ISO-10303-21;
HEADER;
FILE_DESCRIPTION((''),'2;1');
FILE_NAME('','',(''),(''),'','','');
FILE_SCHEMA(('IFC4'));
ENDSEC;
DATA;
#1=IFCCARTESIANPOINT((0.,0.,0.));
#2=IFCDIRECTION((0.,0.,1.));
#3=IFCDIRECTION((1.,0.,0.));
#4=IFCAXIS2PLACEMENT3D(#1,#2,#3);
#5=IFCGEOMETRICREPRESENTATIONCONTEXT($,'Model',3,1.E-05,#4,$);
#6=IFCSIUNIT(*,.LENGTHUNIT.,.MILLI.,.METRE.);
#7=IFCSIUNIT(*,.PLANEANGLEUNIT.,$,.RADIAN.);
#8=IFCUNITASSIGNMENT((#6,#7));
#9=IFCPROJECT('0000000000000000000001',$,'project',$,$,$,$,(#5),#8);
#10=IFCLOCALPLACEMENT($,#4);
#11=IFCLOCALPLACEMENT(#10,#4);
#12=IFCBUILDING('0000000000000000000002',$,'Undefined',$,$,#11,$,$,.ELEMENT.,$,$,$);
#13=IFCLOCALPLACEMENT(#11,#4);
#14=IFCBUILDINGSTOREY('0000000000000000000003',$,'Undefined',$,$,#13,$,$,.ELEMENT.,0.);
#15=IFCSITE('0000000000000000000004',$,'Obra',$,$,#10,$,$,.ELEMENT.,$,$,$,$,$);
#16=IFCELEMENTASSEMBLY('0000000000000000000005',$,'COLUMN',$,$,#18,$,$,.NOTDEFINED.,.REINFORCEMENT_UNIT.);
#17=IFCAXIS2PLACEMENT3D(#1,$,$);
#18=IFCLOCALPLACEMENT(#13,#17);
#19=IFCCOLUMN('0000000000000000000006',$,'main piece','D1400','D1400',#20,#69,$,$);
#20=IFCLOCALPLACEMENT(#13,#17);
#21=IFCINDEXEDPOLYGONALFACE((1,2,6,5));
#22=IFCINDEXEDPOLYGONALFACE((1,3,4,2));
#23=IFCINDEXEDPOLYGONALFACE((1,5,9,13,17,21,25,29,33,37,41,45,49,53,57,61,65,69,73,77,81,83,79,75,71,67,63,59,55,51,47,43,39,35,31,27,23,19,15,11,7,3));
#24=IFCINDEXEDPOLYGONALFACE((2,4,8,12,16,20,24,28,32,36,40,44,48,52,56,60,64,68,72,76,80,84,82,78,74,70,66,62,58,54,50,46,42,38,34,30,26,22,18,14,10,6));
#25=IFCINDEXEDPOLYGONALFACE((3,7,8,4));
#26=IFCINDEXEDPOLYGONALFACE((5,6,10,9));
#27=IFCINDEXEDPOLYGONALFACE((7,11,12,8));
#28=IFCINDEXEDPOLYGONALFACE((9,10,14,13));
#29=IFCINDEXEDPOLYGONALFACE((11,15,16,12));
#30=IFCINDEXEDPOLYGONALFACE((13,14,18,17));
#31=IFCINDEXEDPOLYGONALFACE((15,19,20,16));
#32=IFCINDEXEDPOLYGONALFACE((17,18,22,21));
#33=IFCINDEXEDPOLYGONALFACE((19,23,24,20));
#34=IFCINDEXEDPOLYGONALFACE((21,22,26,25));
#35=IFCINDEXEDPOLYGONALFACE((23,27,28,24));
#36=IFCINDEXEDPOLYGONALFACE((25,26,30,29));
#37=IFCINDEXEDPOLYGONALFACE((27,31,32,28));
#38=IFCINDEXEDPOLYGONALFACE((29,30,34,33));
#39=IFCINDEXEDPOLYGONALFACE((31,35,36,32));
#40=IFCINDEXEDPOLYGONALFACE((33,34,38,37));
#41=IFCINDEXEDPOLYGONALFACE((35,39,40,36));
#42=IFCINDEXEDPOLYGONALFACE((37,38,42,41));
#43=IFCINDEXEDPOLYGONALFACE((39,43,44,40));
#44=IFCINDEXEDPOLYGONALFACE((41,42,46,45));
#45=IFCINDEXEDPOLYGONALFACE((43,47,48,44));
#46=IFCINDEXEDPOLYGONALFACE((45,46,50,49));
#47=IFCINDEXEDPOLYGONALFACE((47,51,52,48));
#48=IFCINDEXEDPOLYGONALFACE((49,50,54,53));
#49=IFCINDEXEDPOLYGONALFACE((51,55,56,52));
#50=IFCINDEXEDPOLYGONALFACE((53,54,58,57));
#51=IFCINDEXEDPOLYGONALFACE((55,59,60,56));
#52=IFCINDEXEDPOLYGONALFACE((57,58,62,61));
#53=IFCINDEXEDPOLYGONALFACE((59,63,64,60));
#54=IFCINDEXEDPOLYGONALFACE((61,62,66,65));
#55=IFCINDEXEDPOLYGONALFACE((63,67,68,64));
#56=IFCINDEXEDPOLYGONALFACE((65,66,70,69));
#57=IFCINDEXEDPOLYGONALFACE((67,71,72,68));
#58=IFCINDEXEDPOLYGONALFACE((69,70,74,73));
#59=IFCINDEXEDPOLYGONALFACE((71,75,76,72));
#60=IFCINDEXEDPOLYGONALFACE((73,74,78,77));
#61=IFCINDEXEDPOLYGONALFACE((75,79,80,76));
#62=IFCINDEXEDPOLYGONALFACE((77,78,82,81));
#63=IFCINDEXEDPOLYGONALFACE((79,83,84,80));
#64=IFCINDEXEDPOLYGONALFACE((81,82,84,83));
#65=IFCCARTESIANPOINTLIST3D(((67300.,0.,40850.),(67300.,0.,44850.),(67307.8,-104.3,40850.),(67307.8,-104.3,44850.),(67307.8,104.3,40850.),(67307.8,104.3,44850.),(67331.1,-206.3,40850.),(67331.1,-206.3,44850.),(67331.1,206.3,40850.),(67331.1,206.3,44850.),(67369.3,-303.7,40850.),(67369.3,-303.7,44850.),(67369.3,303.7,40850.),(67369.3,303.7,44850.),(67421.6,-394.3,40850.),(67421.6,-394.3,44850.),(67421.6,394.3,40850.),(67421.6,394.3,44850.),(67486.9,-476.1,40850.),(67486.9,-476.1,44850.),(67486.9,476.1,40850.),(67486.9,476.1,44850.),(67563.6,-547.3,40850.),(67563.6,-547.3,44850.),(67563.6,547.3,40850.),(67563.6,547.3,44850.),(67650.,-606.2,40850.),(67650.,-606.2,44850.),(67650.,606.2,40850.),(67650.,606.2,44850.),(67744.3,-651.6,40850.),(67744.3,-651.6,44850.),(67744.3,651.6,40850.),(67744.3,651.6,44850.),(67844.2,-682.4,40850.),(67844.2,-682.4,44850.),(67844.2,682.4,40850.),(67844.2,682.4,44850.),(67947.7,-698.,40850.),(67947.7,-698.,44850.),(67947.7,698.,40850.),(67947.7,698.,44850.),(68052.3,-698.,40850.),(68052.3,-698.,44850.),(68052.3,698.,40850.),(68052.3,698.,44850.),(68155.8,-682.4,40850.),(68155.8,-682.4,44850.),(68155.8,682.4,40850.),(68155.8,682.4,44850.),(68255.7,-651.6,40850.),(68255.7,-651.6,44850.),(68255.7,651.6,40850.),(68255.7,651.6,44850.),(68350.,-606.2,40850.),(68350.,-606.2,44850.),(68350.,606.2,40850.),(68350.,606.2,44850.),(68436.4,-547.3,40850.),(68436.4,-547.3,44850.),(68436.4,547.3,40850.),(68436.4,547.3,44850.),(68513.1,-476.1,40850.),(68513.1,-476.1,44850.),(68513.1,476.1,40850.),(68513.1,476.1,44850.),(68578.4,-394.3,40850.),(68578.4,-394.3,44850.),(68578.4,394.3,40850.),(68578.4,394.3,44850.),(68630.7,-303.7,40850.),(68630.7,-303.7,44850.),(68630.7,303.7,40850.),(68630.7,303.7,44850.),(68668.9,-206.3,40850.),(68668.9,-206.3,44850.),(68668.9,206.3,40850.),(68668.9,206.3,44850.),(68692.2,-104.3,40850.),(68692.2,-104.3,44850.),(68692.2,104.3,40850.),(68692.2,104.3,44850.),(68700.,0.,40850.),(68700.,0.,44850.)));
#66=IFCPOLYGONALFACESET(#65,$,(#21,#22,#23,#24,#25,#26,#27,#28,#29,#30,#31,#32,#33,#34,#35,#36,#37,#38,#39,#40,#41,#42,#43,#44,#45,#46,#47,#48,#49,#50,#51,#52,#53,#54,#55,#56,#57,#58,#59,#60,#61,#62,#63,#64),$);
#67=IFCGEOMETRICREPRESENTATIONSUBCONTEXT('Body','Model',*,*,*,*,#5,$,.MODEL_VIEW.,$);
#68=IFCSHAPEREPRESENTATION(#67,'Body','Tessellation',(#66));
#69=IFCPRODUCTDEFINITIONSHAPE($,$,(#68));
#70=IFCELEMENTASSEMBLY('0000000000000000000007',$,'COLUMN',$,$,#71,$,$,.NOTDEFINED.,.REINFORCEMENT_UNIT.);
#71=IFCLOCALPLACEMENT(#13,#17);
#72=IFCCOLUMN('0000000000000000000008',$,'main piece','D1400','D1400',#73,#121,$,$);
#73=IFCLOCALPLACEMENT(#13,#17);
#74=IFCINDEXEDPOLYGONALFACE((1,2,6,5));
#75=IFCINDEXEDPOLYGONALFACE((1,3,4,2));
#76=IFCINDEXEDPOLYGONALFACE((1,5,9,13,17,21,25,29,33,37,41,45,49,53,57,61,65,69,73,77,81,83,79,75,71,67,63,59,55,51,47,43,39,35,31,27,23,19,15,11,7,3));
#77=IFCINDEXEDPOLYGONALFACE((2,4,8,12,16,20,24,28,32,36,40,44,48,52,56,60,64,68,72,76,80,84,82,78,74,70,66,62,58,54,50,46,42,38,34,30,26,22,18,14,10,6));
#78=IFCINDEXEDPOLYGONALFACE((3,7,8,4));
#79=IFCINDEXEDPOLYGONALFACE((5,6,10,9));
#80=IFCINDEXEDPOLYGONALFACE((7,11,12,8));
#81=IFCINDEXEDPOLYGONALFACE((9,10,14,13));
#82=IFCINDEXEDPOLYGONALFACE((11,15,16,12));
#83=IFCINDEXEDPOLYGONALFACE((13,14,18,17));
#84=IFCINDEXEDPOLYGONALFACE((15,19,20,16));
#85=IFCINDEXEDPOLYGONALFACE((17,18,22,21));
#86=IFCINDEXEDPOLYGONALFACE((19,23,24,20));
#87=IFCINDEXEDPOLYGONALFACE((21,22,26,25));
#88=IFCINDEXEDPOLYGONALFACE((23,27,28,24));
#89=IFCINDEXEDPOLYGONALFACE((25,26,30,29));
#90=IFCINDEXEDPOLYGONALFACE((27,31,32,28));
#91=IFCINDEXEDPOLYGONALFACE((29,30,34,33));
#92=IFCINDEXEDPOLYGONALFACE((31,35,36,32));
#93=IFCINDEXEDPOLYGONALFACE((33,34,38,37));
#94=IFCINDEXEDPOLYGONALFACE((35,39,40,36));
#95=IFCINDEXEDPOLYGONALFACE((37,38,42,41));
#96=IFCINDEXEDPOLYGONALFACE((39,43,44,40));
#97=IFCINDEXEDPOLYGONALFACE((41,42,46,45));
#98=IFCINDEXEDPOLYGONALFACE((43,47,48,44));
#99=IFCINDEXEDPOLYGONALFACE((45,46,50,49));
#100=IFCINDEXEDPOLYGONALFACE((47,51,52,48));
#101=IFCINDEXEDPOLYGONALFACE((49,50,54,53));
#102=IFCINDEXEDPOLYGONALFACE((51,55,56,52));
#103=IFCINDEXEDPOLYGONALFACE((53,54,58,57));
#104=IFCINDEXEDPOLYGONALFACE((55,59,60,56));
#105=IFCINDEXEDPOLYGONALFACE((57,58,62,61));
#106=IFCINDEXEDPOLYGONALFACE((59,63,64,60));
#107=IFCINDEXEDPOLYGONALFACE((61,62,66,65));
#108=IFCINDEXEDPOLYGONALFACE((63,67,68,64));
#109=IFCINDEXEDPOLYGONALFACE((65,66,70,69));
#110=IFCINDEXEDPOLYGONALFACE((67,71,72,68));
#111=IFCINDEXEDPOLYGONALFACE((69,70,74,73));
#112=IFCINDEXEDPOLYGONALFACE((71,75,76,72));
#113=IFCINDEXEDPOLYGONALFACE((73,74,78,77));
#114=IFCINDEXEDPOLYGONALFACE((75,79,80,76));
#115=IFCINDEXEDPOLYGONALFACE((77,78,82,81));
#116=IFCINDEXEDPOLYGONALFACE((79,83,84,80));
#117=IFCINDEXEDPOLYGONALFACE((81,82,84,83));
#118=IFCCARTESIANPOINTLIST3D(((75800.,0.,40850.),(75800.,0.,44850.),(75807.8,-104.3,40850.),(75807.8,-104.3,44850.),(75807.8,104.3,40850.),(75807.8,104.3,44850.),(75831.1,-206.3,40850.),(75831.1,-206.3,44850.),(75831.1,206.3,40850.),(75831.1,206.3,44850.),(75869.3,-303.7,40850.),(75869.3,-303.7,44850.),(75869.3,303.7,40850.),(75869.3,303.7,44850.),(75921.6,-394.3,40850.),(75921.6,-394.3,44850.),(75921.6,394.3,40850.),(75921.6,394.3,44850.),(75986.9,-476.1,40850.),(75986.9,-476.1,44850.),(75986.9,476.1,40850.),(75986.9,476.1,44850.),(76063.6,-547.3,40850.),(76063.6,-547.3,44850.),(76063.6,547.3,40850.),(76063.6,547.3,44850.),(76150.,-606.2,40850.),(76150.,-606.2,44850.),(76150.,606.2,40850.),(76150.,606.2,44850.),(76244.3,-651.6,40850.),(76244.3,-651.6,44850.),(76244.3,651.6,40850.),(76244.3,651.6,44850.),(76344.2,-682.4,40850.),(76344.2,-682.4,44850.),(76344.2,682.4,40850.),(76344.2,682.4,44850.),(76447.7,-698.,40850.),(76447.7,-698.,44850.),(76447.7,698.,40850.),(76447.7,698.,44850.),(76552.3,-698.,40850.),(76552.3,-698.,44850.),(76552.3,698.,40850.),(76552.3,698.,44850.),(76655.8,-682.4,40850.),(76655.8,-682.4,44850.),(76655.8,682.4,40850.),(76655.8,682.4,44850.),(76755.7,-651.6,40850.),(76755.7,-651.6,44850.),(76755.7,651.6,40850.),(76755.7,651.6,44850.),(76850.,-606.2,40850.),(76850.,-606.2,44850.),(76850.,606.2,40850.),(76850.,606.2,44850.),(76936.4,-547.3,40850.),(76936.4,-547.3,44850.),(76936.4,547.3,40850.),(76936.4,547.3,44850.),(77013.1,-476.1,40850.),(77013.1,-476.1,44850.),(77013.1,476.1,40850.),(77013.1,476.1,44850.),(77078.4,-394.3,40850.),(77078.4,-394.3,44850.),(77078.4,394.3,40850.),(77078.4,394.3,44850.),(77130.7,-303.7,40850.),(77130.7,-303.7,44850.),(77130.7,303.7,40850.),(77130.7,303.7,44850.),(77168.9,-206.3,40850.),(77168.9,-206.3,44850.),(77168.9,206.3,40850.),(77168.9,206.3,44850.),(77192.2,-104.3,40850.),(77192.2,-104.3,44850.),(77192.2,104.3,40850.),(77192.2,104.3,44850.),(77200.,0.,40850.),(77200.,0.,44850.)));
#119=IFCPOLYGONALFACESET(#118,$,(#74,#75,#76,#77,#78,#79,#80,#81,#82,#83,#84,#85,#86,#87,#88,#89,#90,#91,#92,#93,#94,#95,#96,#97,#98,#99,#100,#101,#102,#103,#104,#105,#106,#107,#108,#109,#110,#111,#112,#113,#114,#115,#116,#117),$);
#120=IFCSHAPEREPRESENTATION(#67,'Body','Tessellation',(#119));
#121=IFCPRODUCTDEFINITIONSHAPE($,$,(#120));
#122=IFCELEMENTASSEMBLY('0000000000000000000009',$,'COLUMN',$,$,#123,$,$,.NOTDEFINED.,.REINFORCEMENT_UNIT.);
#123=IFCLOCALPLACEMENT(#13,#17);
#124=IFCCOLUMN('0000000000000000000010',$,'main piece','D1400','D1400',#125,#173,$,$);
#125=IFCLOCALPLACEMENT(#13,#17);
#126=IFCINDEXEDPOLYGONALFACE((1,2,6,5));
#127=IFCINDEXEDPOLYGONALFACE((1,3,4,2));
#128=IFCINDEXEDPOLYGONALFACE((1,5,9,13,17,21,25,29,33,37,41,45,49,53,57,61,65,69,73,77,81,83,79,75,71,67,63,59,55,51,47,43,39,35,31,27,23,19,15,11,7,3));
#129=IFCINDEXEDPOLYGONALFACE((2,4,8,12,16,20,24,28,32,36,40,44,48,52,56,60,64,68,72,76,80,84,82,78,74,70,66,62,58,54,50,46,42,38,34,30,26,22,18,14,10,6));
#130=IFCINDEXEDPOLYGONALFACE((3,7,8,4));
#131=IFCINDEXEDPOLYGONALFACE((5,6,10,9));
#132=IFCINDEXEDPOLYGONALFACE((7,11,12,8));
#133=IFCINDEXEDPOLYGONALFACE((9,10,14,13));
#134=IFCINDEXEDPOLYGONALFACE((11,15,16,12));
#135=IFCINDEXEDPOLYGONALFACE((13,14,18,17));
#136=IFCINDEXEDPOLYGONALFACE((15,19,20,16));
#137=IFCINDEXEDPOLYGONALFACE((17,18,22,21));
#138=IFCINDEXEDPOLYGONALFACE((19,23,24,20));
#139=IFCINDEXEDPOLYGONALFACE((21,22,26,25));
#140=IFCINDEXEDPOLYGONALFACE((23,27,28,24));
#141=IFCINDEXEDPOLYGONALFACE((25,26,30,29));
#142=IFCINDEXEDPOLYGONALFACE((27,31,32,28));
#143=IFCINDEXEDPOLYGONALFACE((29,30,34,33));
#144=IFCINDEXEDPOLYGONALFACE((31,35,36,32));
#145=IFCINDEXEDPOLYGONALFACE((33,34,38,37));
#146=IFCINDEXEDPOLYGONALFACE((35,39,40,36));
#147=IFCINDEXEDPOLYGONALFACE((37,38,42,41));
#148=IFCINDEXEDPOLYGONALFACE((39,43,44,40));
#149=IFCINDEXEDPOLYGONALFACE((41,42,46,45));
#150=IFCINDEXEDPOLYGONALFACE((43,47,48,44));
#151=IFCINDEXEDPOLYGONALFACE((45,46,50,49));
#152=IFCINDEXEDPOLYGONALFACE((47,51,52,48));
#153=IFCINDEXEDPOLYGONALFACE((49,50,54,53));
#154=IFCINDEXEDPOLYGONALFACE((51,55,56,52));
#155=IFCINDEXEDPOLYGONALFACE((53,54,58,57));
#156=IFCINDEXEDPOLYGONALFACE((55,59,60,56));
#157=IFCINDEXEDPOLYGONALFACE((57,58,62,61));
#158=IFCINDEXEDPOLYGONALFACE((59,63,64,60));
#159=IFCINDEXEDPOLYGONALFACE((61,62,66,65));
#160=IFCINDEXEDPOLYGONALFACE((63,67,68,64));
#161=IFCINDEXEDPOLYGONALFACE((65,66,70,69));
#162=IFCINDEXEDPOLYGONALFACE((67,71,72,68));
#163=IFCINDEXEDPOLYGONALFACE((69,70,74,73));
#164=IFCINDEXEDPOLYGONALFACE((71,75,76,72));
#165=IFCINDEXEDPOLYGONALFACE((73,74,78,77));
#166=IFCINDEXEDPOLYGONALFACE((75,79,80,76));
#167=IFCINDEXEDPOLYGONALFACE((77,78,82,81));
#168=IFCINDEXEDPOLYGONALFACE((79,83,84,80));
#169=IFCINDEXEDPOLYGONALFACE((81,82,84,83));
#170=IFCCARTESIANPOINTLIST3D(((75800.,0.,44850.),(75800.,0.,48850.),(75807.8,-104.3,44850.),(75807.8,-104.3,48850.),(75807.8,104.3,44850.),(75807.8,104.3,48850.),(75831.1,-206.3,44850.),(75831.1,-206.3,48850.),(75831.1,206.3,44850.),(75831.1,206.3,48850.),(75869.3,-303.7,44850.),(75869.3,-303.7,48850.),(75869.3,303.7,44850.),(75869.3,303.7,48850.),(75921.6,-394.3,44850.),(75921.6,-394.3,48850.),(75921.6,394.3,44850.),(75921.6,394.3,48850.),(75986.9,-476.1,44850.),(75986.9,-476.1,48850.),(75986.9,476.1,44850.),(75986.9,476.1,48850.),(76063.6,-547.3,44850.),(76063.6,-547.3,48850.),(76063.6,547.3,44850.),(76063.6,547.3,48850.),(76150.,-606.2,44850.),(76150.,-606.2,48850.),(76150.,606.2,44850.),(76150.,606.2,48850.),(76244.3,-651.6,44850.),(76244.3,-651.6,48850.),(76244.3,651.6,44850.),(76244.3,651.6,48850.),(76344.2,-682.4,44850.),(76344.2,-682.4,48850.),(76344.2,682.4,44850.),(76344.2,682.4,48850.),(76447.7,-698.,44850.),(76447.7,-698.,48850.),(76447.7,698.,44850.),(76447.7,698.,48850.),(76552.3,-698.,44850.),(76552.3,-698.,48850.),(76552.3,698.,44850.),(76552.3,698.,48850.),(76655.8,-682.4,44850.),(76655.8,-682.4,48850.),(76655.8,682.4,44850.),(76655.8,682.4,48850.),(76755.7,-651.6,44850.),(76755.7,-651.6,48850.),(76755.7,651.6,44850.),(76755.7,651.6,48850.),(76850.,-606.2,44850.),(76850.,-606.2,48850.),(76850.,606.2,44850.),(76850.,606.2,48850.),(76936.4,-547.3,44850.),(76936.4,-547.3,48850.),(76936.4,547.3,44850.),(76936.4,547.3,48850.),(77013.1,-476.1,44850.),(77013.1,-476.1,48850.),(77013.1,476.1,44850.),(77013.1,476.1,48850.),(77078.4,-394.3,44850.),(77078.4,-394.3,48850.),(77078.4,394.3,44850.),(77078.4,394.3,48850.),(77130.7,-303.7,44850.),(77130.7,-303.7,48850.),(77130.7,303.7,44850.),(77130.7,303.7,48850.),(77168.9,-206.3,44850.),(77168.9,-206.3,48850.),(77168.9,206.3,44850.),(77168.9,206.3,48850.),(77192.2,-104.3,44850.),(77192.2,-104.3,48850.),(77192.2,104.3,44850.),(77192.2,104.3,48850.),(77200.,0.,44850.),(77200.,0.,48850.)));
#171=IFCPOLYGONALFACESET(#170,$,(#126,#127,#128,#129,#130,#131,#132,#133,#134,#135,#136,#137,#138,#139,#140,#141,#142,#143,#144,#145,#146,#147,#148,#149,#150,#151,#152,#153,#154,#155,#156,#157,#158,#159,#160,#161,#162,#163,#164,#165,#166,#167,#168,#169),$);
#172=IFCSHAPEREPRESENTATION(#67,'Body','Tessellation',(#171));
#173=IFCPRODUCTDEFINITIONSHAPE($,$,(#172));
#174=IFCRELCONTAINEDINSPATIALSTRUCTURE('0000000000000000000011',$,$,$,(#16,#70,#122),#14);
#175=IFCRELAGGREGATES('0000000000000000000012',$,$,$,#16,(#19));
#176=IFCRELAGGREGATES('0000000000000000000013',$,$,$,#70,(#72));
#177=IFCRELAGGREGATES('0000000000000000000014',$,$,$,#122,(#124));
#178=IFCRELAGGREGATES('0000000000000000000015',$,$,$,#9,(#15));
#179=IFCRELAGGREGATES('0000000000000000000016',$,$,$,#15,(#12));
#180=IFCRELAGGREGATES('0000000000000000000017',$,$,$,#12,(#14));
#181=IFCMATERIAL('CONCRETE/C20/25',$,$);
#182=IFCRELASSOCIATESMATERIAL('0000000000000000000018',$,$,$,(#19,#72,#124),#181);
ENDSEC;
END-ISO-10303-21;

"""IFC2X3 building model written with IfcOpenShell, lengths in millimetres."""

from ifc_helpers import new_model, si_unit, frame, origin_with_axes, origin_2d_with_axis, place, context, subcontext, project, spatial, circle, extrude, material, element, aggregate, save


model = new_model("IFC2X3")

# Units and contexts
model_context = context("Model", 3, precision=1e-05, world=origin_with_axes())
body_context = subcontext(model_context, "Body", "Model", "MODEL_VIEW")
ifc_project = project(units=[si_unit("LENGTHUNIT", "METRE", prefix="MILLI"), si_unit("PLANEANGLEUNIT", "RADIAN")], contexts=[model_context])

# Site, building, storey
site_placement = place(None, origin_with_axes())
site = spatial("IfcSite", under=ifc_project, at=site_placement, Name="Obra", CompositionType="ELEMENT")
building_placement = place(site_placement, origin_with_axes())
building = spatial("IfcBuilding", under=site, at=building_placement, Name="Undefined", CompositionType="ELEMENT")
storey_placement = place(building_placement, origin_with_axes())
storey = spatial("IfcBuildingStorey", under=building, at=storey_placement, Name="Undefined", CompositionType="ELEMENT", Elevation=0.0)

# Element assemblies, columns
assembly_1_placement = place(storey_placement, origin_with_axes())
assembly_1 = element("IfcElementAssembly", 1, at=assembly_1_placement, inside=storey, Name="COLUMN", AssemblyPlace="NOTDEFINED", PredefinedType="REINFORCEMENT_UNIT")
ifc_material_1 = material(Name="CONCRETE/C20/25")
column_1_placement = place(assembly_1_placement, frame((68000.0, 0.0, 40850.0), z_axis=(0.0, 0.0, 1.0), x_axis=(0.0, 1.0, 0.0)))
column_1 = element("IfcColumn", 2, at=column_1_placement, material=ifc_material_1, Name="main piece", Description="D1400", ObjectType="D1400", context=body_context, shape_type="SweptSolid", body=[
    extrude(circle(Radius=700.0, at=origin_2d_with_axis()), frame((0.0, 0.0, 4000.0), z_axis=(0.0, 0.0, -1.0), x_axis=(0.0, 1.0, 0.0)), (0.0, 0.0, 1.0), 4000.0),
])
aggregate(assembly_1, [column_1])
assembly_2_placement = place(storey_placement, origin_with_axes())
assembly_2 = element("IfcElementAssembly", 3, at=assembly_2_placement, inside=storey, Name="COLUMN", AssemblyPlace="NOTDEFINED", PredefinedType="REINFORCEMENT_UNIT")
column_2_placement = place(assembly_2_placement, frame((76500.0, 0.0, 40850.0), z_axis=(0.0, 0.0, 1.0), x_axis=(0.0, 1.0, 0.0)))
column_2 = element("IfcColumn", 4, at=column_2_placement, material=ifc_material_1, Name="main piece", Description="D1400", ObjectType="D1400", context=body_context, shape_type="SweptSolid", body=[
    extrude(circle(Radius=700.0, at=origin_2d_with_axis()), frame((0.0, 0.0, 4000.0), z_axis=(0.0, 0.0, -1.0), x_axis=(0.0, 1.0, 0.0)), (0.0, 0.0, 1.0), 4000.0),
])
aggregate(assembly_2, [column_2])
assembly_3_placement = place(storey_placement, origin_with_axes())
assembly_3 = element("IfcElementAssembly", 5, at=assembly_3_placement, inside=storey, Name="COLUMN", AssemblyPlace="NOTDEFINED", PredefinedType="REINFORCEMENT_UNIT")
column_3_placement = place(assembly_3_placement, frame((76500.0, 0.0, 44850.0), z_axis=(0.0, 0.0, 1.0), x_axis=(0.0, 1.0, 0.0)))
column_3 = element("IfcColumn", 6, at=column_3_placement, material=ifc_material_1, Name="main piece", Description="D1400", ObjectType="D1400", context=body_context, shape_type="SweptSolid", body=[
    extrude(circle(Radius=700.0, at=origin_2d_with_axis()), frame((0.0, 0.0, 4000.0), z_axis=(0.0, 0.0, -1.0), x_axis=(0.0, 1.0, 0.0)), (0.0, 0.0, 1.0), 4000.0),
])
aggregate(assembly_3, [column_3])

save(model, "model.ifc")
